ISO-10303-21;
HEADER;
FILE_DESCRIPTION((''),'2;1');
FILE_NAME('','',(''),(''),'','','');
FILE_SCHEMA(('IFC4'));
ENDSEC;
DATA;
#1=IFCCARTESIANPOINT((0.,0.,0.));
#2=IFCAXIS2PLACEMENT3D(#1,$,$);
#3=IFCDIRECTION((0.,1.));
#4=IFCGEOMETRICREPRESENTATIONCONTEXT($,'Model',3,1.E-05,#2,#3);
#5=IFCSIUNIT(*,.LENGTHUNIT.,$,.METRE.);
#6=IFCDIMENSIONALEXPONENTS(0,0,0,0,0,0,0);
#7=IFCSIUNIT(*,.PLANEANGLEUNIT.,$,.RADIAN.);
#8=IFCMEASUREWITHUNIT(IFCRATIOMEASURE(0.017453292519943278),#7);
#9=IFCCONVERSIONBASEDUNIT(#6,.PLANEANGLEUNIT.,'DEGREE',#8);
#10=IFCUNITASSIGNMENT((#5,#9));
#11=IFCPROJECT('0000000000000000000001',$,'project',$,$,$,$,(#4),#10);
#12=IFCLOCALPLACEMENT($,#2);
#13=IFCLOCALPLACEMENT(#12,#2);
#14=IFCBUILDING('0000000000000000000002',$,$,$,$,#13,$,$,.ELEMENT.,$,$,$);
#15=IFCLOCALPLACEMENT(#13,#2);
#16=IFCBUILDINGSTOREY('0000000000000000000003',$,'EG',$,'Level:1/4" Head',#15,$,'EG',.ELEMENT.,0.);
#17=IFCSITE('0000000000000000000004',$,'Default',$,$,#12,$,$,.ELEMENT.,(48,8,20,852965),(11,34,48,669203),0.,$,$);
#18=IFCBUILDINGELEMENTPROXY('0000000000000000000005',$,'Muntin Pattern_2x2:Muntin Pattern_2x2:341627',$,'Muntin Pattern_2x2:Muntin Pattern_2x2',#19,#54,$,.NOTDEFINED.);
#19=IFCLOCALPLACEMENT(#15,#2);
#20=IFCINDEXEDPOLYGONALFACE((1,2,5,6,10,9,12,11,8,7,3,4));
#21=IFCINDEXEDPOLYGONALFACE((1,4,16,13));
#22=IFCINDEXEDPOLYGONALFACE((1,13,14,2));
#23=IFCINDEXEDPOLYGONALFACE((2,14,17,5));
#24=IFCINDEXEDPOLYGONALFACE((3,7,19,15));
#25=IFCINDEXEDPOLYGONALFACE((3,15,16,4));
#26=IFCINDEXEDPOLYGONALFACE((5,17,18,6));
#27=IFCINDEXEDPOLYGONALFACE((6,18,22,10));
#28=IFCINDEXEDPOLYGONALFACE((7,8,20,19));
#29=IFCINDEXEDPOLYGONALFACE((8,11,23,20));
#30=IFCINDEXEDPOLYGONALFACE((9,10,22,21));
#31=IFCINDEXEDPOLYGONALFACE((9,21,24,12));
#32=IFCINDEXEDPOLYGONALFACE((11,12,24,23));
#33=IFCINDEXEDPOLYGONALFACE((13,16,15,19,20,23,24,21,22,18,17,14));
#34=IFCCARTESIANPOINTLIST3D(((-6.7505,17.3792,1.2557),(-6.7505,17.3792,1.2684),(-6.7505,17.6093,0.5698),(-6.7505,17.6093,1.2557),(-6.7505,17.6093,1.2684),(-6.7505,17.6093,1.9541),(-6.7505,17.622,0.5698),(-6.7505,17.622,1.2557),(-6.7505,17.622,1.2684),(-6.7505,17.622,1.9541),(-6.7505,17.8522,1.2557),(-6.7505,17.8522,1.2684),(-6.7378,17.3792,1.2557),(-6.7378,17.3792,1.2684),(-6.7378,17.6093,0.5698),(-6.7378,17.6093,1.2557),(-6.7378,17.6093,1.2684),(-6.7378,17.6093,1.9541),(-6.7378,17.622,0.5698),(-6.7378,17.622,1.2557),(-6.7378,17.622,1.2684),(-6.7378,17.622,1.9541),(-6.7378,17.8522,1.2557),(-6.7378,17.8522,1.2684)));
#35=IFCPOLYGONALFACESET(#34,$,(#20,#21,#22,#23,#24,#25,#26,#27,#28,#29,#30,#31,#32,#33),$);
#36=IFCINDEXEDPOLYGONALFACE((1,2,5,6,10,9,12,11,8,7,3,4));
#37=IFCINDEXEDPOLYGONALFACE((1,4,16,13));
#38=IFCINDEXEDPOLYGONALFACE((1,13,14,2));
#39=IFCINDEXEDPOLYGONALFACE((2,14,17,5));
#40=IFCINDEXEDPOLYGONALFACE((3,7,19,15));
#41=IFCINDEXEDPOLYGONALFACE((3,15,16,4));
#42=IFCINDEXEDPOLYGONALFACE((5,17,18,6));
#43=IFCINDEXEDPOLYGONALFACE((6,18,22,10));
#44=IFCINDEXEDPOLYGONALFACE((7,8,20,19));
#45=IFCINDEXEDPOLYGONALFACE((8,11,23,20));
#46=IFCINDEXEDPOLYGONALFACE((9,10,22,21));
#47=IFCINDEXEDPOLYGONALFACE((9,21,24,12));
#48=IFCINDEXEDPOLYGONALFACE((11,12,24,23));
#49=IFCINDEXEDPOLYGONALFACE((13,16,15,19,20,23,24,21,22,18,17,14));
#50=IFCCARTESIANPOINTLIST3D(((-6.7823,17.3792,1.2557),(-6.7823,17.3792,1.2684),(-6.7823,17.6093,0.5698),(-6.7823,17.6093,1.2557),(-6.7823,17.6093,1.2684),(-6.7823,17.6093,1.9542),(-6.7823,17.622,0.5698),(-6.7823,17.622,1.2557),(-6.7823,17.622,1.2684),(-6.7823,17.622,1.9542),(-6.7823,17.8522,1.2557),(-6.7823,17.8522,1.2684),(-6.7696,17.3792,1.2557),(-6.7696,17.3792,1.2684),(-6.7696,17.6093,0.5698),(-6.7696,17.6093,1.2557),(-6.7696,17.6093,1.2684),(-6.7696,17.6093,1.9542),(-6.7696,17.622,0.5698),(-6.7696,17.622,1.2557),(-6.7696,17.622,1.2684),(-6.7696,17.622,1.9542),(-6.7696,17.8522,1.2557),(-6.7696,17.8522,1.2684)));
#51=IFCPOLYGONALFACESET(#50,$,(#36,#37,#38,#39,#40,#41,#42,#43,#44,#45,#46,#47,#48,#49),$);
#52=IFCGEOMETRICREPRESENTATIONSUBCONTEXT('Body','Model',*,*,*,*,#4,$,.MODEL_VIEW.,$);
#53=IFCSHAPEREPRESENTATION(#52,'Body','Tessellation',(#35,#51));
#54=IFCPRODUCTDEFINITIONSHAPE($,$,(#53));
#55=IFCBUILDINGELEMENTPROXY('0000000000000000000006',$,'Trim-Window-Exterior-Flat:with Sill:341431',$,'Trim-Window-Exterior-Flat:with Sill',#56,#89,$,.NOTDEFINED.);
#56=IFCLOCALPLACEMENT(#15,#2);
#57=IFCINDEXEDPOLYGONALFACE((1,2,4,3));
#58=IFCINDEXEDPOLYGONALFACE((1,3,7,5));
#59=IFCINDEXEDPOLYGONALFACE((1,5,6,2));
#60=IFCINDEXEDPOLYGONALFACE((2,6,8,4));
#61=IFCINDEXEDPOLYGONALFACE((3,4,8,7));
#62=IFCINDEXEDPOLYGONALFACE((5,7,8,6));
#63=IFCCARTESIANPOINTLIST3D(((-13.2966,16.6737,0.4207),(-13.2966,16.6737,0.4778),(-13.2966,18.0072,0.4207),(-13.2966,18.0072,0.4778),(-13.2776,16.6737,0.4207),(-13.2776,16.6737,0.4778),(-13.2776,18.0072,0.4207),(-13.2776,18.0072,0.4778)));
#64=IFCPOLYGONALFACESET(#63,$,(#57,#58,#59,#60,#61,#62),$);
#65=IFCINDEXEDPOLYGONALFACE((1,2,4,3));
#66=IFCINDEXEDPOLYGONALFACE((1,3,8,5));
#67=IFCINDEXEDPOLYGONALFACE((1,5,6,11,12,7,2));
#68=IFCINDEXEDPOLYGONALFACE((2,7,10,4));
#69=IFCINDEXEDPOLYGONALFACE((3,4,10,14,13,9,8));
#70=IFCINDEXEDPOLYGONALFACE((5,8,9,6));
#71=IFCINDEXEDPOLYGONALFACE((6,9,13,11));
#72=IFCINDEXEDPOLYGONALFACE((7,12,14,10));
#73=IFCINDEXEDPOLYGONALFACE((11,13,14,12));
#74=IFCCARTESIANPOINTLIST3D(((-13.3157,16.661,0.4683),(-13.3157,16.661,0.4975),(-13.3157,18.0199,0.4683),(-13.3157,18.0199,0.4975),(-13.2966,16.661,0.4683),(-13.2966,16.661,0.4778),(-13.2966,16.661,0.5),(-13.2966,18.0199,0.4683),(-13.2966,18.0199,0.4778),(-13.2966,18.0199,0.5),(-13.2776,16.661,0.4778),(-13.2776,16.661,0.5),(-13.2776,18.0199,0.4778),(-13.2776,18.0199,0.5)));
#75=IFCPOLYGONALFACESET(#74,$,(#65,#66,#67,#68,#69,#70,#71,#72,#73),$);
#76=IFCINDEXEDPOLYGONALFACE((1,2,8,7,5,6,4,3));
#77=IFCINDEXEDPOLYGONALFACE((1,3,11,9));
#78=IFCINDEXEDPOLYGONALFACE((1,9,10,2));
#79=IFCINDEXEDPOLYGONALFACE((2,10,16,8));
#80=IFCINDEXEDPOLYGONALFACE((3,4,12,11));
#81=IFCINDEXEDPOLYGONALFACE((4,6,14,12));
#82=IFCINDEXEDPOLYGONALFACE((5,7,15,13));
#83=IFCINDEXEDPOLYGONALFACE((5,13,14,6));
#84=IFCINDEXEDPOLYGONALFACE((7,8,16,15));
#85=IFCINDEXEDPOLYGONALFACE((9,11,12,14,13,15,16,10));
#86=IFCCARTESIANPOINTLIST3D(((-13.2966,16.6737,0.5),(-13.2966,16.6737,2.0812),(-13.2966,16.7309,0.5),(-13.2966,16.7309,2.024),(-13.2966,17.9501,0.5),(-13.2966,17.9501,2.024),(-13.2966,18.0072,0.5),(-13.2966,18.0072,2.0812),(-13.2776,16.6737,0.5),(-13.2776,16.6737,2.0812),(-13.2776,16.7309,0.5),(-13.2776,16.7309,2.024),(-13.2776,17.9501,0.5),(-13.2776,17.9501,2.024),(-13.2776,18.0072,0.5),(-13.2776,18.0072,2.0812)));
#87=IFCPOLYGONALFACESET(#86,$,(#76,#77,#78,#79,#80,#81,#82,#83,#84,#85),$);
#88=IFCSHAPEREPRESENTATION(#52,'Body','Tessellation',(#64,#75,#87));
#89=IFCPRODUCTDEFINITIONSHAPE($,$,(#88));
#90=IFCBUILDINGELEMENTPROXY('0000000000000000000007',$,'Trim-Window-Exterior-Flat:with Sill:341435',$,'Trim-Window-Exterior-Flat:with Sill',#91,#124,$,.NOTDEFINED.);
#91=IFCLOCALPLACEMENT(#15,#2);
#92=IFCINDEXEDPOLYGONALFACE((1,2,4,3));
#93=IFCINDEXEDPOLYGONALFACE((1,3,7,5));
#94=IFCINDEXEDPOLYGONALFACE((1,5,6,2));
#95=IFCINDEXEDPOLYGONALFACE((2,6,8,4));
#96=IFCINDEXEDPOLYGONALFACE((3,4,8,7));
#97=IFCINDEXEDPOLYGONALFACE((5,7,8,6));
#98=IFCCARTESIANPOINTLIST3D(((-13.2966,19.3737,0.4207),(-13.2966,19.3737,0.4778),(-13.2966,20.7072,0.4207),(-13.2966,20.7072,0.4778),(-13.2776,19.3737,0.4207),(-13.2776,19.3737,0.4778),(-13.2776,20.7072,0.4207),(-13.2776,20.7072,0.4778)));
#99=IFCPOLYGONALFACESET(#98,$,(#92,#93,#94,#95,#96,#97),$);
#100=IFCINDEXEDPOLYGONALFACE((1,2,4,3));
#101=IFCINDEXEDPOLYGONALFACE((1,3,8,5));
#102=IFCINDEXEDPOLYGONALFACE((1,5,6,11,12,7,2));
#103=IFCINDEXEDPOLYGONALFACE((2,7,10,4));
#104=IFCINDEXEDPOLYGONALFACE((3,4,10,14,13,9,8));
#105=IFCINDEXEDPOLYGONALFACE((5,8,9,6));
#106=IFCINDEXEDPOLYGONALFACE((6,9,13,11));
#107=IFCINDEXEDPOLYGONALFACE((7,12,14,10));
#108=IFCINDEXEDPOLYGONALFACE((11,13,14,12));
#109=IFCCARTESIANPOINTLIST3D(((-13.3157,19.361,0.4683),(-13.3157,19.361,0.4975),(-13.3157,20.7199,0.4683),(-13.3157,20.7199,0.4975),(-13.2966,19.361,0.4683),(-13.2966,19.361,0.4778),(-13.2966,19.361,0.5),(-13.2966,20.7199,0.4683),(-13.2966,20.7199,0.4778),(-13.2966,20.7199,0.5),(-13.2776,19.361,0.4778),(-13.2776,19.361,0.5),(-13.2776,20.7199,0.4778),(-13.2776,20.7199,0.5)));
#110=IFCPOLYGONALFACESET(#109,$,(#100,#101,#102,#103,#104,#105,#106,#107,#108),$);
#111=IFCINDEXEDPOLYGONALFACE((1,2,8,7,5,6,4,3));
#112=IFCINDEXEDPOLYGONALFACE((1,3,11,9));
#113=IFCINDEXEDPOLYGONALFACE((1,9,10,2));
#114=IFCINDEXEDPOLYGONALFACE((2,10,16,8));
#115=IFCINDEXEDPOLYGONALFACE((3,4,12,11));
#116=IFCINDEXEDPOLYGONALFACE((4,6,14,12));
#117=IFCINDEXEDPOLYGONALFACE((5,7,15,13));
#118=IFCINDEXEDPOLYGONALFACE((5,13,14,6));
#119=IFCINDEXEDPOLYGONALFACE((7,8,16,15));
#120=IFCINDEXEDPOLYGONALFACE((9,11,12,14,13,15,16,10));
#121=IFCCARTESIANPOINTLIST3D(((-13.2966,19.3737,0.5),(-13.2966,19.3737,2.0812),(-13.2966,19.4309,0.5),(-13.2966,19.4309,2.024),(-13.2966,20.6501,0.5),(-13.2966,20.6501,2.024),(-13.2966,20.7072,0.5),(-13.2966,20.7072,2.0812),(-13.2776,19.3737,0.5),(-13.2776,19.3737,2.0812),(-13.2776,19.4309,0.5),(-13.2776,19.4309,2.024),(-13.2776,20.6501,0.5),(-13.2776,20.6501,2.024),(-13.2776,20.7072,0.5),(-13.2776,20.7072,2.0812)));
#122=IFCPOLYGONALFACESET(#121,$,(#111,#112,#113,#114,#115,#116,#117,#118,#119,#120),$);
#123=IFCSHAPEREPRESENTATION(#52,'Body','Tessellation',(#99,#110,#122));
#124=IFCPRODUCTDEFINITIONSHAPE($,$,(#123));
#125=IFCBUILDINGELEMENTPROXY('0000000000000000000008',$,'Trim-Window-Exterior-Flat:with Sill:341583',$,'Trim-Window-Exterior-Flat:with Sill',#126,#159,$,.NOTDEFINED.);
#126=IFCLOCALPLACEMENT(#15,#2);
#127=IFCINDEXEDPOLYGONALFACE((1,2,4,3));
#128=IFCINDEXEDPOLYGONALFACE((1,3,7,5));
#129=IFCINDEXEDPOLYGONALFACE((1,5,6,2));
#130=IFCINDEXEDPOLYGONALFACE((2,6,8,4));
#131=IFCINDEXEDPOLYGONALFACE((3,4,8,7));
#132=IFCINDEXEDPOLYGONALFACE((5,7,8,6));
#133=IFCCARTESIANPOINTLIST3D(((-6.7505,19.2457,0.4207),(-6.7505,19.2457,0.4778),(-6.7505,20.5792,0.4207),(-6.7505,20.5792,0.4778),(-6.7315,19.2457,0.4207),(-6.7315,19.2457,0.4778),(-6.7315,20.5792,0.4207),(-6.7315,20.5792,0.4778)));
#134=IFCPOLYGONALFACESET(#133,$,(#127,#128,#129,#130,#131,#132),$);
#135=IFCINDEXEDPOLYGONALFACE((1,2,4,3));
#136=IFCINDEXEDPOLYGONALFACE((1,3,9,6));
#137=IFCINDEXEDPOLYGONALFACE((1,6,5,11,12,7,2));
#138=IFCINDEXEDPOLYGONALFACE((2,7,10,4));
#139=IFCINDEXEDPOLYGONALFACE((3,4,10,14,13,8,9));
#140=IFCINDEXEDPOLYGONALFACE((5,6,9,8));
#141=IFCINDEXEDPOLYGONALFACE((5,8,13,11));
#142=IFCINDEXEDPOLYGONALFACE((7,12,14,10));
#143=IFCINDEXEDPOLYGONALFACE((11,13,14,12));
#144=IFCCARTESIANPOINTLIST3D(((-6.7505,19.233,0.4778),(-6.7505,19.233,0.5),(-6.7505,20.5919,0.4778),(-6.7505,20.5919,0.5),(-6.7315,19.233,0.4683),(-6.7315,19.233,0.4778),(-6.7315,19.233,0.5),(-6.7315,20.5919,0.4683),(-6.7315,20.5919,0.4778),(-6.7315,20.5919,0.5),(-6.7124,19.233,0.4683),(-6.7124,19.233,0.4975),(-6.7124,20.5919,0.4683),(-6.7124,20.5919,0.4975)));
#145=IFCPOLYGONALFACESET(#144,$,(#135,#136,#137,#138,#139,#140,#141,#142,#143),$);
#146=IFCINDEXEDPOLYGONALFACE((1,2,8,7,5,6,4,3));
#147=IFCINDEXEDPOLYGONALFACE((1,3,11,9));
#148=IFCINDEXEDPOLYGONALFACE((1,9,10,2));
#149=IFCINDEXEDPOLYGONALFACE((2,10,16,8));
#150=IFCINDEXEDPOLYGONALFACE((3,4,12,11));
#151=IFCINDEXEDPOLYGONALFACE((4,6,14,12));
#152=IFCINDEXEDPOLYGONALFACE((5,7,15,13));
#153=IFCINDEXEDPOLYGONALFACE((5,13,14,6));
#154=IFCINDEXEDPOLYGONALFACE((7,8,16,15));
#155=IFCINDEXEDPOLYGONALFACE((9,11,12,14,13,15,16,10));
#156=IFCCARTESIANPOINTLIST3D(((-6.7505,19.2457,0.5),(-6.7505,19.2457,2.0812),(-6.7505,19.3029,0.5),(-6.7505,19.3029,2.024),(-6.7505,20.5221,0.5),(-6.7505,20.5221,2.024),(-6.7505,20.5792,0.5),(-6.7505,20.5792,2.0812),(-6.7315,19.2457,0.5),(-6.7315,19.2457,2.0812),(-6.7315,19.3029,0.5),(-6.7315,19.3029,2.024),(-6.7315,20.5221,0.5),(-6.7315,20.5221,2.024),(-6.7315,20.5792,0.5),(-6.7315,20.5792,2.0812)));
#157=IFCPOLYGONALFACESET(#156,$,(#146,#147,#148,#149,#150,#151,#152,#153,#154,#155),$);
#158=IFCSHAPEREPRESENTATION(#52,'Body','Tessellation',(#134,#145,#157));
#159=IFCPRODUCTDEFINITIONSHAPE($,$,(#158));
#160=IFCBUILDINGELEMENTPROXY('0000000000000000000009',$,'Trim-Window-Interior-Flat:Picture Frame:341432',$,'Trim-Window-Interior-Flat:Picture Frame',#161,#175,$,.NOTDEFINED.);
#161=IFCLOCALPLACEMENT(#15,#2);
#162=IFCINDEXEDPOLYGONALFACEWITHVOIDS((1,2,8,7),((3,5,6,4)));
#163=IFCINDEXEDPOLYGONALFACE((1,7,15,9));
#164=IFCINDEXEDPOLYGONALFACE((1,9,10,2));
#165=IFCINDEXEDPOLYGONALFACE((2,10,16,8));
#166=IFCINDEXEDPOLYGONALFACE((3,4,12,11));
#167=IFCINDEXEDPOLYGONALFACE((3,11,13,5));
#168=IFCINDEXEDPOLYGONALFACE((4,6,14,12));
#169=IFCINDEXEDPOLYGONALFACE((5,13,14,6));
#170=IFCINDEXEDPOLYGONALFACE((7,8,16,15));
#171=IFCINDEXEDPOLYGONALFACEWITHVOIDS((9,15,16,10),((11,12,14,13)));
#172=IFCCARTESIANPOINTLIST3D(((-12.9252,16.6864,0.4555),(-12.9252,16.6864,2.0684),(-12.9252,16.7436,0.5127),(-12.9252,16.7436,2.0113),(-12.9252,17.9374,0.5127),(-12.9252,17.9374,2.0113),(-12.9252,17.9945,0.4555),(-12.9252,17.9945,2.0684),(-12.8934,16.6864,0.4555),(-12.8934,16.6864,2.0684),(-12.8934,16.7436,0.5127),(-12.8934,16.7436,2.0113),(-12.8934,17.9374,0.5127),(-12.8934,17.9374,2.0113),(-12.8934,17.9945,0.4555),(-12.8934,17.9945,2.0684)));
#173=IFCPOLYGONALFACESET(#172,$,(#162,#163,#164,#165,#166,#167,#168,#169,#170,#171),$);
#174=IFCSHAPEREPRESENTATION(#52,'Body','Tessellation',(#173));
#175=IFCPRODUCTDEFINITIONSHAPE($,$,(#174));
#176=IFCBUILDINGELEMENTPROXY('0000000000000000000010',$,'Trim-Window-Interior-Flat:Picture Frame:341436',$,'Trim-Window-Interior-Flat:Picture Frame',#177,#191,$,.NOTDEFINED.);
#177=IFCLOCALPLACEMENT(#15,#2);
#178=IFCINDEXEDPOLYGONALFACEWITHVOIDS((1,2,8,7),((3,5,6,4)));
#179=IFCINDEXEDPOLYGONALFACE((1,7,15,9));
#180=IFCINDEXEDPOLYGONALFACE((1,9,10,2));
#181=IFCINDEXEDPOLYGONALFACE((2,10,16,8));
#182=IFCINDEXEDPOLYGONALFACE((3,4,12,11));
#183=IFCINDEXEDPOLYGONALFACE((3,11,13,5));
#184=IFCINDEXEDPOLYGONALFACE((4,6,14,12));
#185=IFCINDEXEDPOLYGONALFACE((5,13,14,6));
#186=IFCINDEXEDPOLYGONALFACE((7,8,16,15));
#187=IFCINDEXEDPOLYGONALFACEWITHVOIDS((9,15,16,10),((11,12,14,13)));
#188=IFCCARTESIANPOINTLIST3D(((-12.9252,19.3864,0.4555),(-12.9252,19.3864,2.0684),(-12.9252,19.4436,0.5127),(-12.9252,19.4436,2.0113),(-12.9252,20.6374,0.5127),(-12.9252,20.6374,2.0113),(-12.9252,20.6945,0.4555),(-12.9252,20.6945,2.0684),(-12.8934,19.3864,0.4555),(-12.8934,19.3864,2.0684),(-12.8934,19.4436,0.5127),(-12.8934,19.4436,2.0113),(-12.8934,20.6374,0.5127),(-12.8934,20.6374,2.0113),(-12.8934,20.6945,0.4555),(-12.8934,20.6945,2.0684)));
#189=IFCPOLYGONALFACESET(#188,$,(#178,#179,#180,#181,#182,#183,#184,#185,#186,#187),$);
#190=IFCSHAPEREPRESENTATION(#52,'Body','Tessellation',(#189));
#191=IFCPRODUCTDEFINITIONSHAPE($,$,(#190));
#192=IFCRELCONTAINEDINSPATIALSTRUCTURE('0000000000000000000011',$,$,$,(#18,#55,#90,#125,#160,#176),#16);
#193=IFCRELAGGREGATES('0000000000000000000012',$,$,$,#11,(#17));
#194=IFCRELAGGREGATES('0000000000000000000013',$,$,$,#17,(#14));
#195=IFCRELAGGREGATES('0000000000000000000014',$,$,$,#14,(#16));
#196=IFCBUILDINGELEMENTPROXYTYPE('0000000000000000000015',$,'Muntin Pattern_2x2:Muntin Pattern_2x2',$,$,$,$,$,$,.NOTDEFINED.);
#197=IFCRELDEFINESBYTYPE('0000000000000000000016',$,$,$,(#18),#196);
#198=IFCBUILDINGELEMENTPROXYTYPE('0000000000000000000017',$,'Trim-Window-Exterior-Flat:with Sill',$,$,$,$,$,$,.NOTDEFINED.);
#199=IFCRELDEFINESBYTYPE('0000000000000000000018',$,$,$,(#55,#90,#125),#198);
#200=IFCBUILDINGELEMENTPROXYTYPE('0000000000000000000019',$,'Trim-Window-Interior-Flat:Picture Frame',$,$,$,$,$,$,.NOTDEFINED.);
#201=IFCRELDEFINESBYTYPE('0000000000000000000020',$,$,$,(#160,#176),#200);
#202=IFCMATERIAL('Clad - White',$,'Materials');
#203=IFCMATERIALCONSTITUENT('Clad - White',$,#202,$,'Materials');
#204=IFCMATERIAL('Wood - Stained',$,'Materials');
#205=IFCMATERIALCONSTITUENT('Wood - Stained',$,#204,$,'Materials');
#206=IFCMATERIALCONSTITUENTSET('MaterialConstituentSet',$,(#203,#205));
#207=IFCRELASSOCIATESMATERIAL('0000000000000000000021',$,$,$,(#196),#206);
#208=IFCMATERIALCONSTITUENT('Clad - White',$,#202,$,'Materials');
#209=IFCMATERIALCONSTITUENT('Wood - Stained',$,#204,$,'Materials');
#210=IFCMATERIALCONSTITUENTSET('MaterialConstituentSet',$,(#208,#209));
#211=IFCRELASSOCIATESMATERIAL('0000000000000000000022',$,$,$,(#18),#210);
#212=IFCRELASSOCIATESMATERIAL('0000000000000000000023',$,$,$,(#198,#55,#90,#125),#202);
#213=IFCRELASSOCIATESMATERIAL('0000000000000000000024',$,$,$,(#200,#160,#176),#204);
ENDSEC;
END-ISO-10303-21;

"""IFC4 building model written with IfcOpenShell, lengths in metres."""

from ifc_helpers import new_model, entity, si_unit, converted_unit, direction, frame, origin, place, context, subcontext, project, spatial, indexed_curve, outline, extrude, source, transform, mapped, material, constituent, constituent_set, type_object, type_shapes, element, save


model = new_model("IFC4")

# Units and contexts
model_context = context("Model", 3, precision=1e-05, world=origin(), true_north=direction((0.0, 1.0)))
body_context = subcontext(model_context, "Body", "Model", "MODEL_VIEW")
ifc_project = project(units=[si_unit("LENGTHUNIT", "METRE"), converted_unit("PLANEANGLEUNIT", "DEGREE", entity("IfcRatioMeasure", 0.017453292519943278), si_unit("PLANEANGLEUNIT", "RADIAN"), dimensions=[0, 0, 0, 0, 0, 0, 0])], contexts=[model_context])

# Site, building, storey
site_placement = place(None, origin())
site = spatial("IfcSite", under=ifc_project, at=site_placement, Name="Default", CompositionType="ELEMENT", RefLatitude=(48, 8, 20, 852965), RefLongitude=(11, 34, 48, 669203), RefElevation=0.0)
building_placement = place(site_placement, origin())
building = spatial("IfcBuilding", under=site, at=building_placement, CompositionType="ELEMENT")
storey_placement = place(building_placement, origin())
storey = spatial("IfcBuildingStorey", under=building, at=storey_placement, Name="EG", ObjectType="Level:1/4\" Head", LongName="EG", CompositionType="ELEMENT", Elevation=0.0)

# Building element proxies
ifc_material_1 = material(Name="Clad - White", Category="Materials")
ifc_material_2 = material(Name="Wood - Stained", Category="Materials")
ifc_constituent_1 = constituent(ifc_material_1, Name="Clad - White", Category="Materials")
ifc_constituent_2 = constituent(ifc_material_2, Name="Wood - Stained", Category="Materials")
ifc_constituent_set_1 = constituent_set(constituents=[ifc_constituent_1, ifc_constituent_2], Name="MaterialConstituentSet")
building_element_proxy_type_1 = type_object("IfcBuildingElementProxyType", Name="Muntin Pattern_2x2:Muntin Pattern_2x2", PredefinedType="NOTDEFINED", material=ifc_constituent_set_1)
shared_shape_1 = source(origin(), body_context, "Body", "SweptSolid", [
    extrude(outline(indexed_curve([(0.0064, -0.0064), (0.6921, -0.0064), (0.6921, 0.0063), (0.0064, 0.0063), (0.0064, 0.2365), (-0.0063, 0.2365), (-0.0063, 0.0063), (-0.6922, 0.0063), (-0.6922, -0.0064), (-0.0063, -0.0064), (-0.0063, -0.2365), (0.0064, -0.2365), (0.0064, -0.0064)], self_intersect=False)), frame((0.0, 0.0095, 0.6921), z_axis=(0.0, 1.0, 0.0), x_axis=(0.0, 0.0, 1.0)), (0.0, 0.0, 1.0), 0.0127),
    extrude(outline(indexed_curve([(0.0064, -0.0064), (0.6922, -0.0064), (0.6922, 0.0063), (0.0064, 0.0063), (0.0064, 0.2365), (-0.0063, 0.2365), (-0.0063, 0.0063), (-0.6922, 0.0063), (-0.6922, -0.0064), (-0.0063, -0.0064), (-0.0063, -0.2365), (0.0064, -0.2365), (0.0064, -0.0064)], self_intersect=False)), frame((0.0, -0.0222, 0.6922), z_axis=(0.0, 1.0, 0.0), x_axis=(0.0, 0.0, 1.0)), (0.0, 0.0, 1.0), 0.0127),
])
type_shapes(building_element_proxy_type_1, [shared_shape_1])
ifc_constituent_3 = constituent(ifc_material_1, Name="Clad - White", Category="Materials")
ifc_constituent_4 = constituent(ifc_material_2, Name="Wood - Stained", Category="Materials")
ifc_constituent_set_2 = constituent_set(constituents=[ifc_constituent_3, ifc_constituent_4], Name="MaterialConstituentSet")
proxy_1_placement = place(storey_placement, frame((-6.7601, 17.6157, 0.5699), z_axis=(0.0, 0.0, 1.0), x_axis=(0.0, -1.0, 0.0)))
element("IfcBuildingElementProxy", 1, at=proxy_1_placement, inside=storey, type_object=building_element_proxy_type_1, material=ifc_constituent_set_2, Name="Muntin Pattern_2x2:Muntin Pattern_2x2:341627", ObjectType="Muntin Pattern_2x2:Muntin Pattern_2x2", PredefinedType="NOTDEFINED", context=body_context, shape_type="MappedRepresentation", body=[
    mapped(shared_shape_1, transform((0.0, 0.0, 0.0), scale=1.0)),
])
building_element_proxy_type_2 = type_object("IfcBuildingElementProxyType", Name="Trim-Window-Exterior-Flat:with Sill", PredefinedType="NOTDEFINED", material=ifc_material_1)
shared_shape_2 = source(origin(), body_context, "Body", "SweptSolid", [
    extrude(outline(indexed_curve([(-0.6667, -0.0286), (0.6667, -0.0286), (0.6667, 0.0286), (-0.6667, 0.0286), (-0.6667, -0.0286)], self_intersect=False)), frame((0.0, -1.5748, 0.0), z_axis=(0.0, 0.0, 1.0), x_axis=(-1.0, 0.0, 0.0)), (0.0, 0.0, 1.0), 0.019),
    extrude(outline(indexed_curve([(-0.019, -0.016), (0.0, -0.016), (0.0, -0.0064), (0.019, -0.0064), (0.019, 0.0158), (0.0, 0.0158), (-0.019, 0.0133), (-0.019, -0.016)], self_intersect=False)), frame((-0.6794, -1.5398, 0.019), z_axis=(1.0, 0.0, 0.0), x_axis=(0.0, 0.0, -1.0)), (0.0, 0.0, 1.0), 1.3589),
    extrude(outline(indexed_curve([(-0.8049, -0.6667), (0.7763, -0.6667), (0.7763, -0.6096), (-0.7477, -0.6096), (-0.7477, 0.6096), (0.7763, 0.6096), (0.7763, 0.6667), (-0.8049, 0.6667), (-0.8049, -0.6667)], self_intersect=False)), frame((0.0, -0.7477, 0.0), z_axis=(0.0, 0.0, 1.0), x_axis=(0.0, -1.0, 0.0)), (0.0, 0.0, 1.0), 0.019),
])
type_shapes(building_element_proxy_type_2, [shared_shape_2])
for number, where, z_axis, x_axis, name in (
    (2, (-13.2776, 17.3405, 2.024), (-1.0, 0.0, 0.0), (0.0, -1.0, 0.0), "Trim-Window-Exterior-Flat:with Sill:341431"),
    (3, (-13.2776, 20.0405, 2.024), (-1.0, 0.0, 0.0), (0.0, -1.0, 0.0), "Trim-Window-Exterior-Flat:with Sill:341435"),
    (4, (-6.7505, 19.9125, 2.024), (1.0, 0.0, 0.0), (0.0, 1.0, 0.0), "Trim-Window-Exterior-Flat:with Sill:341583"),
):
    element("IfcBuildingElementProxy", number, at=place(storey_placement, frame(where, z_axis=z_axis, x_axis=x_axis)), inside=storey, type_object=building_element_proxy_type_2, material=ifc_material_1, Name=name, ObjectType="Trim-Window-Exterior-Flat:with Sill", PredefinedType="NOTDEFINED", context=body_context, shape_type="MappedRepresentation", body=[
        mapped(shared_shape_2, transform((0.0, 0.0, 0.0), scale=1.0)),
    ])
building_element_proxy_type_3 = type_object("IfcBuildingElementProxyType", Name="Trim-Window-Interior-Flat:Picture Frame", PredefinedType="NOTDEFINED", material=ifc_material_2)
shared_shape_3 = source(origin(), body_context, "Body", "SweptSolid", [
    extrude(outline(indexed_curve([(-0.654, -0.8064), (0.654, -0.8064), (0.654, 0.8064), (-0.654, 0.8064), (-0.654, -0.8064)], self_intersect=False), holes=[indexed_curve([(-0.5969, -0.7493), (-0.5969, 0.7493), (0.5969, 0.7493), (0.5969, -0.7493), (-0.5969, -0.7493)], self_intersect=False)]), frame((0.0, -0.762, 0.0), z_axis=(0.0, 0.0, 1.0), x_axis=(-1.0, 0.0, 0.0)), (0.0, 0.0, 1.0), 0.0317),
])
type_shapes(building_element_proxy_type_3, [shared_shape_3])
for number, where, z_axis, x_axis, name in (
    (5, (-12.9252, 17.3405, 2.024), (1.0, 0.0, 0.0), (0.0, 1.0, 0.0), "Trim-Window-Interior-Flat:Picture Frame:341432"),
    (6, (-12.9252, 20.0405, 2.024), (1.0, 0.0, 0.0), (0.0, 1.0, 0.0), "Trim-Window-Interior-Flat:Picture Frame:341436"),
):
    element("IfcBuildingElementProxy", number, at=place(storey_placement, frame(where, z_axis=z_axis, x_axis=x_axis)), inside=storey, type_object=building_element_proxy_type_3, material=ifc_material_2, Name=name, ObjectType="Trim-Window-Interior-Flat:Picture Frame", PredefinedType="NOTDEFINED", context=body_context, shape_type="MappedRepresentation", body=[
        mapped(shared_shape_3, transform((0.0, 0.0, 0.0), scale=1.0)),
    ])

save(model, "model.ifc")
